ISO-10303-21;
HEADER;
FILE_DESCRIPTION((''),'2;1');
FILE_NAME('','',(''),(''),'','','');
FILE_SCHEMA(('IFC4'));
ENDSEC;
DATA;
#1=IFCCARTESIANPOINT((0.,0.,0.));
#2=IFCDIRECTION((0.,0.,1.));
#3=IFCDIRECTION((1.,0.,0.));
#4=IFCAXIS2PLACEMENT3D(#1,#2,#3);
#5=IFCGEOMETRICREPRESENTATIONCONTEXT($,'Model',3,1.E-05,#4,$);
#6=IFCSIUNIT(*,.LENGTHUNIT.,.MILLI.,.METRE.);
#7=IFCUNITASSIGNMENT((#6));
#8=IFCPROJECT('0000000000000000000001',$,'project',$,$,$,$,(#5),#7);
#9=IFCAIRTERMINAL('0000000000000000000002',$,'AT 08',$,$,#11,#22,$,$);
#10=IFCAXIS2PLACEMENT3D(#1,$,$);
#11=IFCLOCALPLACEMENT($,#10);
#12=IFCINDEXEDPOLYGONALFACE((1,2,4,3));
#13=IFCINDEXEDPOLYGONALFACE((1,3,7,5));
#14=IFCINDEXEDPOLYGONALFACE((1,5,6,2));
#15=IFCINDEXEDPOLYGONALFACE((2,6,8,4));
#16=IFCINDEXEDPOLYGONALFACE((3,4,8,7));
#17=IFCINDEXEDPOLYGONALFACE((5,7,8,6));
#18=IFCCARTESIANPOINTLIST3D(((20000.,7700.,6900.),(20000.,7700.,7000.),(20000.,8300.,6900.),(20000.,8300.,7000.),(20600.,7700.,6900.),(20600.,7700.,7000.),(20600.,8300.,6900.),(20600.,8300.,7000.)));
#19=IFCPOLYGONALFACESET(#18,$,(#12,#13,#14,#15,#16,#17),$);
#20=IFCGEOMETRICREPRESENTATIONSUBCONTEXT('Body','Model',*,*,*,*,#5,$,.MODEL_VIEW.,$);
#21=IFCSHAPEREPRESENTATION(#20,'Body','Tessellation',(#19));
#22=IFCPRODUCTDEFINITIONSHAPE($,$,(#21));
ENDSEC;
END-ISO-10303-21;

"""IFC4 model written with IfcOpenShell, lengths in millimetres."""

from ifc_helpers import new_model, si_unit, frame, origin_with_axes, place, context, subcontext, project, indexed_curve, outline, extrude, element, save


model = new_model("IFC4")

# Units and contexts
model_context = context("Model", 3, precision=1e-05, world=origin_with_axes())
body_context = subcontext(model_context, "Body", "Model", "MODEL_VIEW")
ifc_project = project(units=[si_unit("LENGTHUNIT", "METRE", prefix="MILLI")], contexts=[model_context])

# Air terminal
air_terminal_placement = place(None, frame((20000.0, 7700.0, 6900.0), z_axis=(0.0, 0.0, 1.0), x_axis=(1.0, 0.0, 0.0)))
element("IfcAirTerminal", 1, at=air_terminal_placement, Name="AT 08", context=body_context, shape_type="SweptSolid", body=[
    extrude(outline(indexed_curve([(0.0, 0.0), (0.0, 600.0), (600.0, 600.0), (600.0, 0.0), (0.0, 0.0)], self_intersect=False)), origin_with_axes(), (0.0, 0.0, 1.0), 100.0),
])

save(model, "model.ifc")
